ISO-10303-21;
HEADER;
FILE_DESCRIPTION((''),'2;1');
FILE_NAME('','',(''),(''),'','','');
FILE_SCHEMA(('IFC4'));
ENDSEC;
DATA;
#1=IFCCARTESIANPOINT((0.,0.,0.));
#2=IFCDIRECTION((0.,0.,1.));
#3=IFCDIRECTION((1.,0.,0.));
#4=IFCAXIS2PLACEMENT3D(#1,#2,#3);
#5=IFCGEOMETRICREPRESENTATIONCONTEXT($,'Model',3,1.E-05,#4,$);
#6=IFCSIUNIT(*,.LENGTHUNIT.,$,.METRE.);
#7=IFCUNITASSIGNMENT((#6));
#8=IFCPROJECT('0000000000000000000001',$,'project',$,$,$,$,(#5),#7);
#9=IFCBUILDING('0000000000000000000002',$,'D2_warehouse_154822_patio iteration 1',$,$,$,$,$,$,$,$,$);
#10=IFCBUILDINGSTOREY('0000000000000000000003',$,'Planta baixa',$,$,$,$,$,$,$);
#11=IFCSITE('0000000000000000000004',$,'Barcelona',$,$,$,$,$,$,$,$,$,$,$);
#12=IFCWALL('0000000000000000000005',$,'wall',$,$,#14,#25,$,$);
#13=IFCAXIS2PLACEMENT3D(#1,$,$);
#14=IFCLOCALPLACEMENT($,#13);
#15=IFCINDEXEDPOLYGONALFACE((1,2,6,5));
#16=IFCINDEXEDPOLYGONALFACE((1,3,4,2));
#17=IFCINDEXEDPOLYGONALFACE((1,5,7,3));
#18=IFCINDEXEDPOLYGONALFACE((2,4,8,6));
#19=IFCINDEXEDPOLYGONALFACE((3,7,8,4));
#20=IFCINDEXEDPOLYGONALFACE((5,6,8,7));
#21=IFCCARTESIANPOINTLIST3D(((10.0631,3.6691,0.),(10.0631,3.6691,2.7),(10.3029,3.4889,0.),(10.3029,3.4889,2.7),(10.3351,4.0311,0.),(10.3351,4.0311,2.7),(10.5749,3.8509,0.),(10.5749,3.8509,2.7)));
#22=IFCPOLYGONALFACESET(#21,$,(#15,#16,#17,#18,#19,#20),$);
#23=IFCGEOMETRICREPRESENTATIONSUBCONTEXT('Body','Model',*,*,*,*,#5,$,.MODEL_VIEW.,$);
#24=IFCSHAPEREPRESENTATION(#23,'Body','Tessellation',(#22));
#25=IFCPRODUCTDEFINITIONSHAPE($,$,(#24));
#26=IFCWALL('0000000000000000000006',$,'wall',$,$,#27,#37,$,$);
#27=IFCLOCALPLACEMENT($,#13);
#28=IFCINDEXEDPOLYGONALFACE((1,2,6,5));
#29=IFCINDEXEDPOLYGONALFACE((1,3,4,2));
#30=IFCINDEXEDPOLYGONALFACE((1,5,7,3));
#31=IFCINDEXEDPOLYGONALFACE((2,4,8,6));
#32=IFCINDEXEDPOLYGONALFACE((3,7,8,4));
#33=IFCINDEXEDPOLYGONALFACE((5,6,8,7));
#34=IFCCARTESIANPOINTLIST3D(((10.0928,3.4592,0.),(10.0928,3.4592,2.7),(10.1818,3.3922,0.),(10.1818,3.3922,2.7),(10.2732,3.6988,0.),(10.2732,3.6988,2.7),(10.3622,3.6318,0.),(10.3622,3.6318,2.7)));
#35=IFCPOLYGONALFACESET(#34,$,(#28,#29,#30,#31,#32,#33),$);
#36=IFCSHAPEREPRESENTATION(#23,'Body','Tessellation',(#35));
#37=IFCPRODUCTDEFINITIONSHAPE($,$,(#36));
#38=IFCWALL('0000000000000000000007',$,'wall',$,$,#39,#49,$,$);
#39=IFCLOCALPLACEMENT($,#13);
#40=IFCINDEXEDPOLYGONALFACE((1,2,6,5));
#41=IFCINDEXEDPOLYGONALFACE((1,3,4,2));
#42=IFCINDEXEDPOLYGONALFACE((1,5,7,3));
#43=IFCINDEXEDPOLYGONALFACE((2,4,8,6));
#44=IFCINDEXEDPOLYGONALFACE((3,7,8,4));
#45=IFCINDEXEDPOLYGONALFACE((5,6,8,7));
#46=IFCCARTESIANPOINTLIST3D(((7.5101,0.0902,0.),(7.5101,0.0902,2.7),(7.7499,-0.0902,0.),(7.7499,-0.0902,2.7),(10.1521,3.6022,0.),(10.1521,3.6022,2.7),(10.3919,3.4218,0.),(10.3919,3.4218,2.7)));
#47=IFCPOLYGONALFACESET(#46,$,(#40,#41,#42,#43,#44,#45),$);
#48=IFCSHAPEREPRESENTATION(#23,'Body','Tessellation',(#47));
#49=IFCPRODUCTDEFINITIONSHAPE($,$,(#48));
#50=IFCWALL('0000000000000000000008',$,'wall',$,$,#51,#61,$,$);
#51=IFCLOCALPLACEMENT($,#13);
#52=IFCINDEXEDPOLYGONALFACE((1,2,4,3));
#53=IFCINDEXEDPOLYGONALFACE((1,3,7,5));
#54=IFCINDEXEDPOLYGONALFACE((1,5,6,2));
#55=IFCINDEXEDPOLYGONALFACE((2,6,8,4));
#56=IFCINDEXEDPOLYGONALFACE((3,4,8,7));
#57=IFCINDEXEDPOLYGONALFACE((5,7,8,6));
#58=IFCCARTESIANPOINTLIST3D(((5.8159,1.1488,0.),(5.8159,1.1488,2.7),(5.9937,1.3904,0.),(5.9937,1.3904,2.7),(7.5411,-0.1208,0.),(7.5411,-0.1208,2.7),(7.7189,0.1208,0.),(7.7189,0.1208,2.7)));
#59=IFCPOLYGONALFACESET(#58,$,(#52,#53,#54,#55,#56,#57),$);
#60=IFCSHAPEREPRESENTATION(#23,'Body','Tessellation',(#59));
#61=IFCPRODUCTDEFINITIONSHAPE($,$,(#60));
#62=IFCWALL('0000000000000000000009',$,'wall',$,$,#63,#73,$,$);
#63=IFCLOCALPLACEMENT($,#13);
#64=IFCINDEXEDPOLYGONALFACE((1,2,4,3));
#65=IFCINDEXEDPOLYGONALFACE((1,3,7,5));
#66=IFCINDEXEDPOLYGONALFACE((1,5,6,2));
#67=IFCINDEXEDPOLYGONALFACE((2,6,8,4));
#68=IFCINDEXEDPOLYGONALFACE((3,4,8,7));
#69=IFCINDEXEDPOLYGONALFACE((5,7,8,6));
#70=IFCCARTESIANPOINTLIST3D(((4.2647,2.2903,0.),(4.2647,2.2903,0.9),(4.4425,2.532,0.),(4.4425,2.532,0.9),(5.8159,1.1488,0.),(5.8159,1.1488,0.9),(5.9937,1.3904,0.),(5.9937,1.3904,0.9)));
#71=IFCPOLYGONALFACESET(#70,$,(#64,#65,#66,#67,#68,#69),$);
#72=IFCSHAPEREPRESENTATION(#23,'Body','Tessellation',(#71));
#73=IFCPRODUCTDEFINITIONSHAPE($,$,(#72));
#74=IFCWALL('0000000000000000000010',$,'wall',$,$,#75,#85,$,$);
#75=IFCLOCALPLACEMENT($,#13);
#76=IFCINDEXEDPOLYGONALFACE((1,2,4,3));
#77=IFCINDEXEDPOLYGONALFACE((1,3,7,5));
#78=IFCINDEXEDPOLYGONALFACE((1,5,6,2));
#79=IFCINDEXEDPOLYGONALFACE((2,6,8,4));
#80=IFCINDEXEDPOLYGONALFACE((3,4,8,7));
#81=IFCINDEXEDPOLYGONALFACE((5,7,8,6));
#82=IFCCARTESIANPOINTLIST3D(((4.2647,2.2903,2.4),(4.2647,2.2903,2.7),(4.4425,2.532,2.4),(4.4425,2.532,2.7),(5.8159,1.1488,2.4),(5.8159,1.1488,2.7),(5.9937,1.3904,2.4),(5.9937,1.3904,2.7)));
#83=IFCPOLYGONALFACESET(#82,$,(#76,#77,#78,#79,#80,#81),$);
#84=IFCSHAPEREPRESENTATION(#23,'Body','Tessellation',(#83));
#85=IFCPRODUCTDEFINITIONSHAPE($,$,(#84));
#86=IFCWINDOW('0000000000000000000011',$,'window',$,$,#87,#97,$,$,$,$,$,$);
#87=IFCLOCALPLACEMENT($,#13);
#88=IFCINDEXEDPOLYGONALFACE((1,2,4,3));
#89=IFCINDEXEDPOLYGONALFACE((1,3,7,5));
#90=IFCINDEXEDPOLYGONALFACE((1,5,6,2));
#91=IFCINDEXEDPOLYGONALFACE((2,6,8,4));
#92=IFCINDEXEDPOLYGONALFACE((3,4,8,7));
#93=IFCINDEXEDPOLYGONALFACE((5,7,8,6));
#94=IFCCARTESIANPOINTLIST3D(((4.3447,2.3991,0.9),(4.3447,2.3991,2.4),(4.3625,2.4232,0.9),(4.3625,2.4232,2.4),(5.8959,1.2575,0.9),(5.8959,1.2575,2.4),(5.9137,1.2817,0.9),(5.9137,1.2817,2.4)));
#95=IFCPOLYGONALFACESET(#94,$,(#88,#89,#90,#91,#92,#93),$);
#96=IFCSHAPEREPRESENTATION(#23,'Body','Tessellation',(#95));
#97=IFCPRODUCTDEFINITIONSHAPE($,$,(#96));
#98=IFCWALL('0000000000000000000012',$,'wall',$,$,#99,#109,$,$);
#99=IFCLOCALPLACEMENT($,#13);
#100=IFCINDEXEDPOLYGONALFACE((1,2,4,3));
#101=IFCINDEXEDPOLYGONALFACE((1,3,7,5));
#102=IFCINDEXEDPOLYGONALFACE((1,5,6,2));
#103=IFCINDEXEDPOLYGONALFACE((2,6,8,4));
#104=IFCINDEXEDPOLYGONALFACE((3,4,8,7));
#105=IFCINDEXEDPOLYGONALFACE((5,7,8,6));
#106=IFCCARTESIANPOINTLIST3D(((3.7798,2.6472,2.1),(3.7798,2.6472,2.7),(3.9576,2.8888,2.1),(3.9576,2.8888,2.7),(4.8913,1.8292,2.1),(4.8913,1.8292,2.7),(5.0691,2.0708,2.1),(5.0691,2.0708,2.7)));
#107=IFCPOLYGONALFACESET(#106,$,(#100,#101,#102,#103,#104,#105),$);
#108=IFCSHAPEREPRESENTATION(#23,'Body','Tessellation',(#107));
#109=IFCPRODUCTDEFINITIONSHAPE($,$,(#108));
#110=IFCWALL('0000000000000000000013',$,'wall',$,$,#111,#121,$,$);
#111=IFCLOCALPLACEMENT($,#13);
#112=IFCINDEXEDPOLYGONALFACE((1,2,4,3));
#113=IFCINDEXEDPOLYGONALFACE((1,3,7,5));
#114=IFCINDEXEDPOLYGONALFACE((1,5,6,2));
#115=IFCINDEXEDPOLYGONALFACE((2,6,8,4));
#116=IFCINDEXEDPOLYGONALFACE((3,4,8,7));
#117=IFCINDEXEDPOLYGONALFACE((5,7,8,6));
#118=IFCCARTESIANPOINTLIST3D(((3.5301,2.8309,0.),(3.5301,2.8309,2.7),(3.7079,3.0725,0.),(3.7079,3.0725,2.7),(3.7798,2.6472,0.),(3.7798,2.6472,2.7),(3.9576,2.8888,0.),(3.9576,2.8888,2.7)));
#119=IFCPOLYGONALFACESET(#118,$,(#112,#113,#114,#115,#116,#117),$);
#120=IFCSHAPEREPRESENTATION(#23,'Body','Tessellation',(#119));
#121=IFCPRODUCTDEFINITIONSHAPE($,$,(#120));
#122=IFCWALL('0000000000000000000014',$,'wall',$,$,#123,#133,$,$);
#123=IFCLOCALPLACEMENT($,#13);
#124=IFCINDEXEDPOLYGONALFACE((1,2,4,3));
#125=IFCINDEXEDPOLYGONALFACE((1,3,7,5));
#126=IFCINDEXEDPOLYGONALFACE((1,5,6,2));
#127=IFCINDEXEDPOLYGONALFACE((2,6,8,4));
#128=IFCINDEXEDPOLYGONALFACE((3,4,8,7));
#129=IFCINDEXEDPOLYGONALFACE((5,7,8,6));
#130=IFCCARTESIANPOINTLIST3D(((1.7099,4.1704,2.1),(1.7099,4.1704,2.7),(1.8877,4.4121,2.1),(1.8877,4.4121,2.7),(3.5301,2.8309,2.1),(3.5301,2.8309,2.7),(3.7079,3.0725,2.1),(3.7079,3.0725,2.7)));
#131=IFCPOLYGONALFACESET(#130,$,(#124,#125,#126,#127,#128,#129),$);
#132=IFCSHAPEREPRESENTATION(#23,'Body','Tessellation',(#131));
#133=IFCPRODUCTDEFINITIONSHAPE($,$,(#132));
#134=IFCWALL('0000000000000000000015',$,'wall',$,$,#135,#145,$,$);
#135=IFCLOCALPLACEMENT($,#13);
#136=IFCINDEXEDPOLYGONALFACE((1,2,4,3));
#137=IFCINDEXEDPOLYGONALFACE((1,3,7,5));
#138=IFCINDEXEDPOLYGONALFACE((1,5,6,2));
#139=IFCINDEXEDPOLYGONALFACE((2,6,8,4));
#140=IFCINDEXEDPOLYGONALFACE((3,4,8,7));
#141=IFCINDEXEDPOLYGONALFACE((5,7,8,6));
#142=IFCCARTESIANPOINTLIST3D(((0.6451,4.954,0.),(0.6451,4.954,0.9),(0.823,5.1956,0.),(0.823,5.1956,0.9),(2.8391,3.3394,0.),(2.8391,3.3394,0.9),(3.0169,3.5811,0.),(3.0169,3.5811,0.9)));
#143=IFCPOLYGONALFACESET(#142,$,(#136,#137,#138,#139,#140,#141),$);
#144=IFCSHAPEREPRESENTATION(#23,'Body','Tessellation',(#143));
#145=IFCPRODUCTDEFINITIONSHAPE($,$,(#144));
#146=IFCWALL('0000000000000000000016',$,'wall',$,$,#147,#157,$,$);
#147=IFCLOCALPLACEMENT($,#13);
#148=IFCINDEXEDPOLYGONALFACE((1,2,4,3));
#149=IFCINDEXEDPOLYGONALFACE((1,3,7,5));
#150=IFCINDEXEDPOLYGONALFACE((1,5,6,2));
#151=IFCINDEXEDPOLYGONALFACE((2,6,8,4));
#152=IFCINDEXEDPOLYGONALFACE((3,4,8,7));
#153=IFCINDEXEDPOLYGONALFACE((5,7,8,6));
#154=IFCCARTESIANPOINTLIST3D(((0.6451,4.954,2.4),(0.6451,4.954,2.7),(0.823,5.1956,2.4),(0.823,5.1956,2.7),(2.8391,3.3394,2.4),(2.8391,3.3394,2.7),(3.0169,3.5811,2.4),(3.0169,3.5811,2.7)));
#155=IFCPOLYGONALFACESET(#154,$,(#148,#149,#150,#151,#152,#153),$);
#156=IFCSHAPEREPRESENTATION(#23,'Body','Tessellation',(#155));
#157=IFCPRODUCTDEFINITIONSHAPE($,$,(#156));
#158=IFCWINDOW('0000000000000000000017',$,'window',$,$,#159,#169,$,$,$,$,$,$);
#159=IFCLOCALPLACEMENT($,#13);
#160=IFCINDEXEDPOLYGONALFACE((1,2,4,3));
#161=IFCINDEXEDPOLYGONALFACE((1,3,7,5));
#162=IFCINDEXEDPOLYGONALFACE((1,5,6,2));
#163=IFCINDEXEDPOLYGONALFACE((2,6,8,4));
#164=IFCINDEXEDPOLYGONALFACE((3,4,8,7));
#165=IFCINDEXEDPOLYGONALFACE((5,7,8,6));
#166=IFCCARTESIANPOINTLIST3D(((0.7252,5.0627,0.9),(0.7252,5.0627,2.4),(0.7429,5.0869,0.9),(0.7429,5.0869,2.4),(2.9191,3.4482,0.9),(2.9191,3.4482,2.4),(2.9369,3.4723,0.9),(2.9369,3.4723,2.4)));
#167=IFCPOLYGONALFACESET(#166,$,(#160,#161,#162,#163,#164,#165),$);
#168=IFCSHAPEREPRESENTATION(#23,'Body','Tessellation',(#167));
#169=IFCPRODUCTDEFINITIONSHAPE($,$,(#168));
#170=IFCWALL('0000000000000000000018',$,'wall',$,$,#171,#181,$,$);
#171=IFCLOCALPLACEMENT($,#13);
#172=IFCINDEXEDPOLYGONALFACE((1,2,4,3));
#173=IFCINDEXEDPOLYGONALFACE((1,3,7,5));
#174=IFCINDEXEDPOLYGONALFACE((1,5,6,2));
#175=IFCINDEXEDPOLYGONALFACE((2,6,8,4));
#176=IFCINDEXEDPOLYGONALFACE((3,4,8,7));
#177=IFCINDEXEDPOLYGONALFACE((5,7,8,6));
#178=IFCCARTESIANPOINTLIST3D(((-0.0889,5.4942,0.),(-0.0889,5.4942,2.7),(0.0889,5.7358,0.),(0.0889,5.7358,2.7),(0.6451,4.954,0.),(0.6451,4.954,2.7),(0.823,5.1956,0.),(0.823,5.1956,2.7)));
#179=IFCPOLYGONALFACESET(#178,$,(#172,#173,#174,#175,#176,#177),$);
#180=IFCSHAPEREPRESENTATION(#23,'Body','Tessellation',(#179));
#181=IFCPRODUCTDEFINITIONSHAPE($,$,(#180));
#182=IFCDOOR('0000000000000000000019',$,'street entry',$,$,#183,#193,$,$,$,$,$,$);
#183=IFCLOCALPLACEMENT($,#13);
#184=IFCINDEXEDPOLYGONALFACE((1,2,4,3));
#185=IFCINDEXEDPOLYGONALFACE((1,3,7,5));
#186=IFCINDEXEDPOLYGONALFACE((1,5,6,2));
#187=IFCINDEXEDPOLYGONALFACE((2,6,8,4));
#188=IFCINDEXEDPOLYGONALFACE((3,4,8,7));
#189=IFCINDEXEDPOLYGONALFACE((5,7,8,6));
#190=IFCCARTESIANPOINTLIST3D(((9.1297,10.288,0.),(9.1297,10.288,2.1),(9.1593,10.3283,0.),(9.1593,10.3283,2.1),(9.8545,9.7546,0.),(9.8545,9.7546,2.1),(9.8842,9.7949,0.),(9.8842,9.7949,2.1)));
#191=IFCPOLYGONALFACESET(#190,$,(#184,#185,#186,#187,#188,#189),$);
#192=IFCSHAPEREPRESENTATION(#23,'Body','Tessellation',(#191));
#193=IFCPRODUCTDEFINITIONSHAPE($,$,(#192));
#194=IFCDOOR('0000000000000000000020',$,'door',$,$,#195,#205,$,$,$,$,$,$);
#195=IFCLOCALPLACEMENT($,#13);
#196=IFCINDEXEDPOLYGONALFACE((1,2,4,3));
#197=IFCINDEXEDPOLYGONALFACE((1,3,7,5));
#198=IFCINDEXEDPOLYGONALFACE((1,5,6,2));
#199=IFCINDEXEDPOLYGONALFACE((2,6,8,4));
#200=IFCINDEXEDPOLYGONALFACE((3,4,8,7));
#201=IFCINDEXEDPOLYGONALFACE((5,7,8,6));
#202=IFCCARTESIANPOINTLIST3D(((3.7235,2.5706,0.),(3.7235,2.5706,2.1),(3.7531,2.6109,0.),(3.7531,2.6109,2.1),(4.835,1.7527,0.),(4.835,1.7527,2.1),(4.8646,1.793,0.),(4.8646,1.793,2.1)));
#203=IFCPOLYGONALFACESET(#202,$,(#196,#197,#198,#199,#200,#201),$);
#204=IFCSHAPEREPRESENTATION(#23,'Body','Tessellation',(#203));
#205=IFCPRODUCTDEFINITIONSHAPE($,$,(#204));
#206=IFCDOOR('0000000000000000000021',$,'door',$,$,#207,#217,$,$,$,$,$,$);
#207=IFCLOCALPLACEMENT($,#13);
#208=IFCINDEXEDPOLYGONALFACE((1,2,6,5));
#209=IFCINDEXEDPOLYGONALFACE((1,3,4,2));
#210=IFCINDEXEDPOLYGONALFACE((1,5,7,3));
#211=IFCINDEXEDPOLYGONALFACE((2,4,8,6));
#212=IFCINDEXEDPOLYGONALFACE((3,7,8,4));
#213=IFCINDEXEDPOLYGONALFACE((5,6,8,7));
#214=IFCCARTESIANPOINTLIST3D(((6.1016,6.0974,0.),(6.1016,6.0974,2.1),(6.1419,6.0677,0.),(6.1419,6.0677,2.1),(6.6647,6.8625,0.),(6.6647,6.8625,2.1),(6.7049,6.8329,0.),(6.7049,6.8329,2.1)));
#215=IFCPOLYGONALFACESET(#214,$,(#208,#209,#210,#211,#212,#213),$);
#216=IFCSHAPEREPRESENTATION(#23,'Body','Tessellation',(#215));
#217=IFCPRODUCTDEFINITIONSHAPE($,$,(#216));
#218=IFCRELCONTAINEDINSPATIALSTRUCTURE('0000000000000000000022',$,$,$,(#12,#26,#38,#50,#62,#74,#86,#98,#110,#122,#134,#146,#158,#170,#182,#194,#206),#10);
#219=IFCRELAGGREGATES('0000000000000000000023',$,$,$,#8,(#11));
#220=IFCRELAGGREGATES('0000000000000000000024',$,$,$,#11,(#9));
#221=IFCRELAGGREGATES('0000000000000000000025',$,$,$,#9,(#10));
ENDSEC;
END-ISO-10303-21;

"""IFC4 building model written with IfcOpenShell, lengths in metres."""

from ifc_helpers import new_model, si_unit, frame, origin, origin_with_axes, place, context, subcontext, project, spatial, polyline, outline, extrude, element, save


model = new_model("IFC4")

# Units and contexts
model_context = context("Model", 3, precision=1e-05, world=origin_with_axes())
body_context = subcontext(model_context, "Body", "Model", "MODEL_VIEW")
ifc_project = project(units=[si_unit("LENGTHUNIT", "METRE")], contexts=[model_context])

# Site, building, storey
site = spatial("IfcSite", under=ifc_project, Name="Barcelona")
building = spatial("IfcBuilding", under=site, Name="D2_warehouse_154822_patio iteration 1")
storey = spatial("IfcBuildingStorey", under=building, Name="Planta baixa")

# Walls
wall_1_placement = place(None, origin_with_axes())
element("IfcWall", 1, at=wall_1_placement, inside=storey, Name="wall", context=body_context, shape_type="SweptSolid", body=[
    extrude(outline(polyline([(10.5749, 3.8509), (10.3029, 3.4889), (10.0631, 3.6691), (10.3351, 4.0311), (10.5749, 3.8509)])), origin(), (0.0, 0.0, 1.0), 2.7),
])
wall_2_placement = place(None, origin_with_axes())
element("IfcWall", 2, at=wall_2_placement, inside=storey, Name="wall", context=body_context, shape_type="SweptSolid", body=[
    extrude(outline(polyline([(10.2732, 3.6988), (10.3622, 3.6318), (10.1818, 3.3922), (10.0928, 3.4592), (10.2732, 3.6988)])), origin(), (0.0, 0.0, 1.0), 2.7),
])
wall_3_placement = place(None, origin_with_axes())
element("IfcWall", 3, at=wall_3_placement, inside=storey, Name="wall", context=body_context, shape_type="SweptSolid", body=[
    extrude(outline(polyline([(10.3919, 3.4218), (7.7499, -0.0902), (7.5101, 0.0902), (10.1521, 3.6022), (10.3919, 3.4218)])), origin(), (0.0, 0.0, 1.0), 2.7),
])
wall_4_placement = place(None, origin_with_axes())
element("IfcWall", 4, at=wall_4_placement, inside=storey, Name="wall", context=body_context, shape_type="SweptSolid", body=[
    extrude(outline(polyline([(7.5411, -0.1208), (5.8159, 1.1488), (5.9937, 1.3904), (7.7189, 0.1208), (7.5411, -0.1208)])), origin(), (0.0, 0.0, 1.0), 2.7),
])
wall_5_placement = place(None, origin_with_axes())
element("IfcWall", 5, at=wall_5_placement, inside=storey, Name="wall", context=body_context, shape_type="SweptSolid", body=[
    extrude(outline(polyline([(5.8159, 1.1488), (4.2647, 2.2903), (4.4425, 2.532), (5.9937, 1.3904), (5.8159, 1.1488)])), origin(), (0.0, 0.0, 1.0), 0.9),
])
wall_6_placement = place(None, origin_with_axes())
element("IfcWall", 6, at=wall_6_placement, inside=storey, Name="wall", context=body_context, shape_type="SweptSolid", body=[
    extrude(outline(polyline([(5.8159, 1.1488), (4.2647, 2.2903), (4.4425, 2.532), (5.9937, 1.3904), (5.8159, 1.1488)])), frame((0.0, 0.0, 2.4)), (0.0, 0.0, 1.0), 0.3),
])

# Window
window_1_placement = place(None, origin_with_axes())
element("IfcWindow", 7, at=window_1_placement, inside=storey, Name="window", context=body_context, shape_type="SweptSolid", body=[
    extrude(outline(polyline([(5.8959, 1.2575), (4.3447, 2.3991), (4.3625, 2.4232), (5.9137, 1.2817), (5.8959, 1.2575)])), frame((0.0, 0.0, 0.9)), (0.0, 0.0, 1.0), 1.5),
])

# Walls
wall_7_placement = place(None, origin_with_axes())
element("IfcWall", 8, at=wall_7_placement, inside=storey, Name="wall", context=body_context, shape_type="SweptSolid", body=[
    extrude(outline(polyline([(4.8913, 1.8292), (3.7798, 2.6472), (3.9576, 2.8888), (5.0691, 2.0708), (4.8913, 1.8292)])), frame((0.0, 0.0, 2.1)), (0.0, 0.0, 1.0), 0.6),
])
wall_8_placement = place(None, origin_with_axes())
element("IfcWall", 9, at=wall_8_placement, inside=storey, Name="wall", context=body_context, shape_type="SweptSolid", body=[
    extrude(outline(polyline([(3.7798, 2.6472), (3.5301, 2.8309), (3.7079, 3.0725), (3.9576, 2.8888), (3.7798, 2.6472)])), origin(), (0.0, 0.0, 1.0), 2.7),
])
wall_9_placement = place(None, origin_with_axes())
element("IfcWall", 10, at=wall_9_placement, inside=storey, Name="wall", context=body_context, shape_type="SweptSolid", body=[
    extrude(outline(polyline([(3.5301, 2.8309), (1.7099, 4.1704), (1.8877, 4.4121), (3.7079, 3.0725), (3.5301, 2.8309)])), frame((0.0, 0.0, 2.1)), (0.0, 0.0, 1.0), 0.6),
])
wall_10_placement = place(None, origin_with_axes())
element("IfcWall", 11, at=wall_10_placement, inside=storey, Name="wall", context=body_context, shape_type="SweptSolid", body=[
    extrude(outline(polyline([(2.8391, 3.3394), (0.6451, 4.954), (0.823, 5.1956), (3.0169, 3.5811), (2.8391, 3.3394)])), origin(), (0.0, 0.0, 1.0), 0.9),
])
wall_11_placement = place(None, origin_with_axes())
element("IfcWall", 12, at=wall_11_placement, inside=storey, Name="wall", context=body_context, shape_type="SweptSolid", body=[
    extrude(outline(polyline([(2.8391, 3.3394), (0.6451, 4.954), (0.823, 5.1956), (3.0169, 3.5811), (2.8391, 3.3394)])), frame((0.0, 0.0, 2.4)), (0.0, 0.0, 1.0), 0.3),
])

# Window
window_2_placement = place(None, origin_with_axes())
element("IfcWindow", 13, at=window_2_placement, inside=storey, Name="window", context=body_context, shape_type="SweptSolid", body=[
    extrude(outline(polyline([(2.9191, 3.4482), (0.7252, 5.0627), (0.7429, 5.0869), (2.9369, 3.4723), (2.9191, 3.4482)])), frame((0.0, 0.0, 0.9)), (0.0, 0.0, 1.0), 1.5),
])

# Wall
wall_12_placement = place(None, origin_with_axes())
element("IfcWall", 14, at=wall_12_placement, inside=storey, Name="wall", context=body_context, shape_type="SweptSolid", body=[
    extrude(outline(polyline([(0.6451, 4.954), (-0.0889, 5.4942), (0.0889, 5.7358), (0.823, 5.1956), (0.6451, 4.954)])), origin(), (0.0, 0.0, 1.0), 2.7),
])

# Doors
door_1_placement = place(None, origin_with_axes())
element("IfcDoor", 15, at=door_1_placement, inside=storey, Name="street entry", context=body_context, shape_type="SweptSolid", body=[
    extrude(outline(polyline([(9.8545, 9.7546), (9.1297, 10.288), (9.1593, 10.3283), (9.8842, 9.7949), (9.8545, 9.7546)])), origin(), (0.0, 0.0, 1.0), 2.1),
])
door_2_placement = place(None, origin_with_axes())
element("IfcDoor", 16, at=door_2_placement, inside=storey, Name="door", context=body_context, shape_type="SweptSolid", body=[
    extrude(outline(polyline([(4.835, 1.7527), (3.7235, 2.5706), (3.7531, 2.6109), (4.8646, 1.793), (4.835, 1.7527)])), origin(), (0.0, 0.0, 1.0), 2.1),
])
door_3_placement = place(None, origin_with_axes())
element("IfcDoor", 17, at=door_3_placement, inside=storey, Name="door", context=body_context, shape_type="SweptSolid", body=[
    extrude(outline(polyline([(6.1016, 6.0974), (6.6647, 6.8625), (6.7049, 6.8329), (6.1419, 6.0677), (6.1016, 6.0974)])), origin(), (0.0, 0.0, 1.0), 2.1),
])

save(model, "model.ifc")
